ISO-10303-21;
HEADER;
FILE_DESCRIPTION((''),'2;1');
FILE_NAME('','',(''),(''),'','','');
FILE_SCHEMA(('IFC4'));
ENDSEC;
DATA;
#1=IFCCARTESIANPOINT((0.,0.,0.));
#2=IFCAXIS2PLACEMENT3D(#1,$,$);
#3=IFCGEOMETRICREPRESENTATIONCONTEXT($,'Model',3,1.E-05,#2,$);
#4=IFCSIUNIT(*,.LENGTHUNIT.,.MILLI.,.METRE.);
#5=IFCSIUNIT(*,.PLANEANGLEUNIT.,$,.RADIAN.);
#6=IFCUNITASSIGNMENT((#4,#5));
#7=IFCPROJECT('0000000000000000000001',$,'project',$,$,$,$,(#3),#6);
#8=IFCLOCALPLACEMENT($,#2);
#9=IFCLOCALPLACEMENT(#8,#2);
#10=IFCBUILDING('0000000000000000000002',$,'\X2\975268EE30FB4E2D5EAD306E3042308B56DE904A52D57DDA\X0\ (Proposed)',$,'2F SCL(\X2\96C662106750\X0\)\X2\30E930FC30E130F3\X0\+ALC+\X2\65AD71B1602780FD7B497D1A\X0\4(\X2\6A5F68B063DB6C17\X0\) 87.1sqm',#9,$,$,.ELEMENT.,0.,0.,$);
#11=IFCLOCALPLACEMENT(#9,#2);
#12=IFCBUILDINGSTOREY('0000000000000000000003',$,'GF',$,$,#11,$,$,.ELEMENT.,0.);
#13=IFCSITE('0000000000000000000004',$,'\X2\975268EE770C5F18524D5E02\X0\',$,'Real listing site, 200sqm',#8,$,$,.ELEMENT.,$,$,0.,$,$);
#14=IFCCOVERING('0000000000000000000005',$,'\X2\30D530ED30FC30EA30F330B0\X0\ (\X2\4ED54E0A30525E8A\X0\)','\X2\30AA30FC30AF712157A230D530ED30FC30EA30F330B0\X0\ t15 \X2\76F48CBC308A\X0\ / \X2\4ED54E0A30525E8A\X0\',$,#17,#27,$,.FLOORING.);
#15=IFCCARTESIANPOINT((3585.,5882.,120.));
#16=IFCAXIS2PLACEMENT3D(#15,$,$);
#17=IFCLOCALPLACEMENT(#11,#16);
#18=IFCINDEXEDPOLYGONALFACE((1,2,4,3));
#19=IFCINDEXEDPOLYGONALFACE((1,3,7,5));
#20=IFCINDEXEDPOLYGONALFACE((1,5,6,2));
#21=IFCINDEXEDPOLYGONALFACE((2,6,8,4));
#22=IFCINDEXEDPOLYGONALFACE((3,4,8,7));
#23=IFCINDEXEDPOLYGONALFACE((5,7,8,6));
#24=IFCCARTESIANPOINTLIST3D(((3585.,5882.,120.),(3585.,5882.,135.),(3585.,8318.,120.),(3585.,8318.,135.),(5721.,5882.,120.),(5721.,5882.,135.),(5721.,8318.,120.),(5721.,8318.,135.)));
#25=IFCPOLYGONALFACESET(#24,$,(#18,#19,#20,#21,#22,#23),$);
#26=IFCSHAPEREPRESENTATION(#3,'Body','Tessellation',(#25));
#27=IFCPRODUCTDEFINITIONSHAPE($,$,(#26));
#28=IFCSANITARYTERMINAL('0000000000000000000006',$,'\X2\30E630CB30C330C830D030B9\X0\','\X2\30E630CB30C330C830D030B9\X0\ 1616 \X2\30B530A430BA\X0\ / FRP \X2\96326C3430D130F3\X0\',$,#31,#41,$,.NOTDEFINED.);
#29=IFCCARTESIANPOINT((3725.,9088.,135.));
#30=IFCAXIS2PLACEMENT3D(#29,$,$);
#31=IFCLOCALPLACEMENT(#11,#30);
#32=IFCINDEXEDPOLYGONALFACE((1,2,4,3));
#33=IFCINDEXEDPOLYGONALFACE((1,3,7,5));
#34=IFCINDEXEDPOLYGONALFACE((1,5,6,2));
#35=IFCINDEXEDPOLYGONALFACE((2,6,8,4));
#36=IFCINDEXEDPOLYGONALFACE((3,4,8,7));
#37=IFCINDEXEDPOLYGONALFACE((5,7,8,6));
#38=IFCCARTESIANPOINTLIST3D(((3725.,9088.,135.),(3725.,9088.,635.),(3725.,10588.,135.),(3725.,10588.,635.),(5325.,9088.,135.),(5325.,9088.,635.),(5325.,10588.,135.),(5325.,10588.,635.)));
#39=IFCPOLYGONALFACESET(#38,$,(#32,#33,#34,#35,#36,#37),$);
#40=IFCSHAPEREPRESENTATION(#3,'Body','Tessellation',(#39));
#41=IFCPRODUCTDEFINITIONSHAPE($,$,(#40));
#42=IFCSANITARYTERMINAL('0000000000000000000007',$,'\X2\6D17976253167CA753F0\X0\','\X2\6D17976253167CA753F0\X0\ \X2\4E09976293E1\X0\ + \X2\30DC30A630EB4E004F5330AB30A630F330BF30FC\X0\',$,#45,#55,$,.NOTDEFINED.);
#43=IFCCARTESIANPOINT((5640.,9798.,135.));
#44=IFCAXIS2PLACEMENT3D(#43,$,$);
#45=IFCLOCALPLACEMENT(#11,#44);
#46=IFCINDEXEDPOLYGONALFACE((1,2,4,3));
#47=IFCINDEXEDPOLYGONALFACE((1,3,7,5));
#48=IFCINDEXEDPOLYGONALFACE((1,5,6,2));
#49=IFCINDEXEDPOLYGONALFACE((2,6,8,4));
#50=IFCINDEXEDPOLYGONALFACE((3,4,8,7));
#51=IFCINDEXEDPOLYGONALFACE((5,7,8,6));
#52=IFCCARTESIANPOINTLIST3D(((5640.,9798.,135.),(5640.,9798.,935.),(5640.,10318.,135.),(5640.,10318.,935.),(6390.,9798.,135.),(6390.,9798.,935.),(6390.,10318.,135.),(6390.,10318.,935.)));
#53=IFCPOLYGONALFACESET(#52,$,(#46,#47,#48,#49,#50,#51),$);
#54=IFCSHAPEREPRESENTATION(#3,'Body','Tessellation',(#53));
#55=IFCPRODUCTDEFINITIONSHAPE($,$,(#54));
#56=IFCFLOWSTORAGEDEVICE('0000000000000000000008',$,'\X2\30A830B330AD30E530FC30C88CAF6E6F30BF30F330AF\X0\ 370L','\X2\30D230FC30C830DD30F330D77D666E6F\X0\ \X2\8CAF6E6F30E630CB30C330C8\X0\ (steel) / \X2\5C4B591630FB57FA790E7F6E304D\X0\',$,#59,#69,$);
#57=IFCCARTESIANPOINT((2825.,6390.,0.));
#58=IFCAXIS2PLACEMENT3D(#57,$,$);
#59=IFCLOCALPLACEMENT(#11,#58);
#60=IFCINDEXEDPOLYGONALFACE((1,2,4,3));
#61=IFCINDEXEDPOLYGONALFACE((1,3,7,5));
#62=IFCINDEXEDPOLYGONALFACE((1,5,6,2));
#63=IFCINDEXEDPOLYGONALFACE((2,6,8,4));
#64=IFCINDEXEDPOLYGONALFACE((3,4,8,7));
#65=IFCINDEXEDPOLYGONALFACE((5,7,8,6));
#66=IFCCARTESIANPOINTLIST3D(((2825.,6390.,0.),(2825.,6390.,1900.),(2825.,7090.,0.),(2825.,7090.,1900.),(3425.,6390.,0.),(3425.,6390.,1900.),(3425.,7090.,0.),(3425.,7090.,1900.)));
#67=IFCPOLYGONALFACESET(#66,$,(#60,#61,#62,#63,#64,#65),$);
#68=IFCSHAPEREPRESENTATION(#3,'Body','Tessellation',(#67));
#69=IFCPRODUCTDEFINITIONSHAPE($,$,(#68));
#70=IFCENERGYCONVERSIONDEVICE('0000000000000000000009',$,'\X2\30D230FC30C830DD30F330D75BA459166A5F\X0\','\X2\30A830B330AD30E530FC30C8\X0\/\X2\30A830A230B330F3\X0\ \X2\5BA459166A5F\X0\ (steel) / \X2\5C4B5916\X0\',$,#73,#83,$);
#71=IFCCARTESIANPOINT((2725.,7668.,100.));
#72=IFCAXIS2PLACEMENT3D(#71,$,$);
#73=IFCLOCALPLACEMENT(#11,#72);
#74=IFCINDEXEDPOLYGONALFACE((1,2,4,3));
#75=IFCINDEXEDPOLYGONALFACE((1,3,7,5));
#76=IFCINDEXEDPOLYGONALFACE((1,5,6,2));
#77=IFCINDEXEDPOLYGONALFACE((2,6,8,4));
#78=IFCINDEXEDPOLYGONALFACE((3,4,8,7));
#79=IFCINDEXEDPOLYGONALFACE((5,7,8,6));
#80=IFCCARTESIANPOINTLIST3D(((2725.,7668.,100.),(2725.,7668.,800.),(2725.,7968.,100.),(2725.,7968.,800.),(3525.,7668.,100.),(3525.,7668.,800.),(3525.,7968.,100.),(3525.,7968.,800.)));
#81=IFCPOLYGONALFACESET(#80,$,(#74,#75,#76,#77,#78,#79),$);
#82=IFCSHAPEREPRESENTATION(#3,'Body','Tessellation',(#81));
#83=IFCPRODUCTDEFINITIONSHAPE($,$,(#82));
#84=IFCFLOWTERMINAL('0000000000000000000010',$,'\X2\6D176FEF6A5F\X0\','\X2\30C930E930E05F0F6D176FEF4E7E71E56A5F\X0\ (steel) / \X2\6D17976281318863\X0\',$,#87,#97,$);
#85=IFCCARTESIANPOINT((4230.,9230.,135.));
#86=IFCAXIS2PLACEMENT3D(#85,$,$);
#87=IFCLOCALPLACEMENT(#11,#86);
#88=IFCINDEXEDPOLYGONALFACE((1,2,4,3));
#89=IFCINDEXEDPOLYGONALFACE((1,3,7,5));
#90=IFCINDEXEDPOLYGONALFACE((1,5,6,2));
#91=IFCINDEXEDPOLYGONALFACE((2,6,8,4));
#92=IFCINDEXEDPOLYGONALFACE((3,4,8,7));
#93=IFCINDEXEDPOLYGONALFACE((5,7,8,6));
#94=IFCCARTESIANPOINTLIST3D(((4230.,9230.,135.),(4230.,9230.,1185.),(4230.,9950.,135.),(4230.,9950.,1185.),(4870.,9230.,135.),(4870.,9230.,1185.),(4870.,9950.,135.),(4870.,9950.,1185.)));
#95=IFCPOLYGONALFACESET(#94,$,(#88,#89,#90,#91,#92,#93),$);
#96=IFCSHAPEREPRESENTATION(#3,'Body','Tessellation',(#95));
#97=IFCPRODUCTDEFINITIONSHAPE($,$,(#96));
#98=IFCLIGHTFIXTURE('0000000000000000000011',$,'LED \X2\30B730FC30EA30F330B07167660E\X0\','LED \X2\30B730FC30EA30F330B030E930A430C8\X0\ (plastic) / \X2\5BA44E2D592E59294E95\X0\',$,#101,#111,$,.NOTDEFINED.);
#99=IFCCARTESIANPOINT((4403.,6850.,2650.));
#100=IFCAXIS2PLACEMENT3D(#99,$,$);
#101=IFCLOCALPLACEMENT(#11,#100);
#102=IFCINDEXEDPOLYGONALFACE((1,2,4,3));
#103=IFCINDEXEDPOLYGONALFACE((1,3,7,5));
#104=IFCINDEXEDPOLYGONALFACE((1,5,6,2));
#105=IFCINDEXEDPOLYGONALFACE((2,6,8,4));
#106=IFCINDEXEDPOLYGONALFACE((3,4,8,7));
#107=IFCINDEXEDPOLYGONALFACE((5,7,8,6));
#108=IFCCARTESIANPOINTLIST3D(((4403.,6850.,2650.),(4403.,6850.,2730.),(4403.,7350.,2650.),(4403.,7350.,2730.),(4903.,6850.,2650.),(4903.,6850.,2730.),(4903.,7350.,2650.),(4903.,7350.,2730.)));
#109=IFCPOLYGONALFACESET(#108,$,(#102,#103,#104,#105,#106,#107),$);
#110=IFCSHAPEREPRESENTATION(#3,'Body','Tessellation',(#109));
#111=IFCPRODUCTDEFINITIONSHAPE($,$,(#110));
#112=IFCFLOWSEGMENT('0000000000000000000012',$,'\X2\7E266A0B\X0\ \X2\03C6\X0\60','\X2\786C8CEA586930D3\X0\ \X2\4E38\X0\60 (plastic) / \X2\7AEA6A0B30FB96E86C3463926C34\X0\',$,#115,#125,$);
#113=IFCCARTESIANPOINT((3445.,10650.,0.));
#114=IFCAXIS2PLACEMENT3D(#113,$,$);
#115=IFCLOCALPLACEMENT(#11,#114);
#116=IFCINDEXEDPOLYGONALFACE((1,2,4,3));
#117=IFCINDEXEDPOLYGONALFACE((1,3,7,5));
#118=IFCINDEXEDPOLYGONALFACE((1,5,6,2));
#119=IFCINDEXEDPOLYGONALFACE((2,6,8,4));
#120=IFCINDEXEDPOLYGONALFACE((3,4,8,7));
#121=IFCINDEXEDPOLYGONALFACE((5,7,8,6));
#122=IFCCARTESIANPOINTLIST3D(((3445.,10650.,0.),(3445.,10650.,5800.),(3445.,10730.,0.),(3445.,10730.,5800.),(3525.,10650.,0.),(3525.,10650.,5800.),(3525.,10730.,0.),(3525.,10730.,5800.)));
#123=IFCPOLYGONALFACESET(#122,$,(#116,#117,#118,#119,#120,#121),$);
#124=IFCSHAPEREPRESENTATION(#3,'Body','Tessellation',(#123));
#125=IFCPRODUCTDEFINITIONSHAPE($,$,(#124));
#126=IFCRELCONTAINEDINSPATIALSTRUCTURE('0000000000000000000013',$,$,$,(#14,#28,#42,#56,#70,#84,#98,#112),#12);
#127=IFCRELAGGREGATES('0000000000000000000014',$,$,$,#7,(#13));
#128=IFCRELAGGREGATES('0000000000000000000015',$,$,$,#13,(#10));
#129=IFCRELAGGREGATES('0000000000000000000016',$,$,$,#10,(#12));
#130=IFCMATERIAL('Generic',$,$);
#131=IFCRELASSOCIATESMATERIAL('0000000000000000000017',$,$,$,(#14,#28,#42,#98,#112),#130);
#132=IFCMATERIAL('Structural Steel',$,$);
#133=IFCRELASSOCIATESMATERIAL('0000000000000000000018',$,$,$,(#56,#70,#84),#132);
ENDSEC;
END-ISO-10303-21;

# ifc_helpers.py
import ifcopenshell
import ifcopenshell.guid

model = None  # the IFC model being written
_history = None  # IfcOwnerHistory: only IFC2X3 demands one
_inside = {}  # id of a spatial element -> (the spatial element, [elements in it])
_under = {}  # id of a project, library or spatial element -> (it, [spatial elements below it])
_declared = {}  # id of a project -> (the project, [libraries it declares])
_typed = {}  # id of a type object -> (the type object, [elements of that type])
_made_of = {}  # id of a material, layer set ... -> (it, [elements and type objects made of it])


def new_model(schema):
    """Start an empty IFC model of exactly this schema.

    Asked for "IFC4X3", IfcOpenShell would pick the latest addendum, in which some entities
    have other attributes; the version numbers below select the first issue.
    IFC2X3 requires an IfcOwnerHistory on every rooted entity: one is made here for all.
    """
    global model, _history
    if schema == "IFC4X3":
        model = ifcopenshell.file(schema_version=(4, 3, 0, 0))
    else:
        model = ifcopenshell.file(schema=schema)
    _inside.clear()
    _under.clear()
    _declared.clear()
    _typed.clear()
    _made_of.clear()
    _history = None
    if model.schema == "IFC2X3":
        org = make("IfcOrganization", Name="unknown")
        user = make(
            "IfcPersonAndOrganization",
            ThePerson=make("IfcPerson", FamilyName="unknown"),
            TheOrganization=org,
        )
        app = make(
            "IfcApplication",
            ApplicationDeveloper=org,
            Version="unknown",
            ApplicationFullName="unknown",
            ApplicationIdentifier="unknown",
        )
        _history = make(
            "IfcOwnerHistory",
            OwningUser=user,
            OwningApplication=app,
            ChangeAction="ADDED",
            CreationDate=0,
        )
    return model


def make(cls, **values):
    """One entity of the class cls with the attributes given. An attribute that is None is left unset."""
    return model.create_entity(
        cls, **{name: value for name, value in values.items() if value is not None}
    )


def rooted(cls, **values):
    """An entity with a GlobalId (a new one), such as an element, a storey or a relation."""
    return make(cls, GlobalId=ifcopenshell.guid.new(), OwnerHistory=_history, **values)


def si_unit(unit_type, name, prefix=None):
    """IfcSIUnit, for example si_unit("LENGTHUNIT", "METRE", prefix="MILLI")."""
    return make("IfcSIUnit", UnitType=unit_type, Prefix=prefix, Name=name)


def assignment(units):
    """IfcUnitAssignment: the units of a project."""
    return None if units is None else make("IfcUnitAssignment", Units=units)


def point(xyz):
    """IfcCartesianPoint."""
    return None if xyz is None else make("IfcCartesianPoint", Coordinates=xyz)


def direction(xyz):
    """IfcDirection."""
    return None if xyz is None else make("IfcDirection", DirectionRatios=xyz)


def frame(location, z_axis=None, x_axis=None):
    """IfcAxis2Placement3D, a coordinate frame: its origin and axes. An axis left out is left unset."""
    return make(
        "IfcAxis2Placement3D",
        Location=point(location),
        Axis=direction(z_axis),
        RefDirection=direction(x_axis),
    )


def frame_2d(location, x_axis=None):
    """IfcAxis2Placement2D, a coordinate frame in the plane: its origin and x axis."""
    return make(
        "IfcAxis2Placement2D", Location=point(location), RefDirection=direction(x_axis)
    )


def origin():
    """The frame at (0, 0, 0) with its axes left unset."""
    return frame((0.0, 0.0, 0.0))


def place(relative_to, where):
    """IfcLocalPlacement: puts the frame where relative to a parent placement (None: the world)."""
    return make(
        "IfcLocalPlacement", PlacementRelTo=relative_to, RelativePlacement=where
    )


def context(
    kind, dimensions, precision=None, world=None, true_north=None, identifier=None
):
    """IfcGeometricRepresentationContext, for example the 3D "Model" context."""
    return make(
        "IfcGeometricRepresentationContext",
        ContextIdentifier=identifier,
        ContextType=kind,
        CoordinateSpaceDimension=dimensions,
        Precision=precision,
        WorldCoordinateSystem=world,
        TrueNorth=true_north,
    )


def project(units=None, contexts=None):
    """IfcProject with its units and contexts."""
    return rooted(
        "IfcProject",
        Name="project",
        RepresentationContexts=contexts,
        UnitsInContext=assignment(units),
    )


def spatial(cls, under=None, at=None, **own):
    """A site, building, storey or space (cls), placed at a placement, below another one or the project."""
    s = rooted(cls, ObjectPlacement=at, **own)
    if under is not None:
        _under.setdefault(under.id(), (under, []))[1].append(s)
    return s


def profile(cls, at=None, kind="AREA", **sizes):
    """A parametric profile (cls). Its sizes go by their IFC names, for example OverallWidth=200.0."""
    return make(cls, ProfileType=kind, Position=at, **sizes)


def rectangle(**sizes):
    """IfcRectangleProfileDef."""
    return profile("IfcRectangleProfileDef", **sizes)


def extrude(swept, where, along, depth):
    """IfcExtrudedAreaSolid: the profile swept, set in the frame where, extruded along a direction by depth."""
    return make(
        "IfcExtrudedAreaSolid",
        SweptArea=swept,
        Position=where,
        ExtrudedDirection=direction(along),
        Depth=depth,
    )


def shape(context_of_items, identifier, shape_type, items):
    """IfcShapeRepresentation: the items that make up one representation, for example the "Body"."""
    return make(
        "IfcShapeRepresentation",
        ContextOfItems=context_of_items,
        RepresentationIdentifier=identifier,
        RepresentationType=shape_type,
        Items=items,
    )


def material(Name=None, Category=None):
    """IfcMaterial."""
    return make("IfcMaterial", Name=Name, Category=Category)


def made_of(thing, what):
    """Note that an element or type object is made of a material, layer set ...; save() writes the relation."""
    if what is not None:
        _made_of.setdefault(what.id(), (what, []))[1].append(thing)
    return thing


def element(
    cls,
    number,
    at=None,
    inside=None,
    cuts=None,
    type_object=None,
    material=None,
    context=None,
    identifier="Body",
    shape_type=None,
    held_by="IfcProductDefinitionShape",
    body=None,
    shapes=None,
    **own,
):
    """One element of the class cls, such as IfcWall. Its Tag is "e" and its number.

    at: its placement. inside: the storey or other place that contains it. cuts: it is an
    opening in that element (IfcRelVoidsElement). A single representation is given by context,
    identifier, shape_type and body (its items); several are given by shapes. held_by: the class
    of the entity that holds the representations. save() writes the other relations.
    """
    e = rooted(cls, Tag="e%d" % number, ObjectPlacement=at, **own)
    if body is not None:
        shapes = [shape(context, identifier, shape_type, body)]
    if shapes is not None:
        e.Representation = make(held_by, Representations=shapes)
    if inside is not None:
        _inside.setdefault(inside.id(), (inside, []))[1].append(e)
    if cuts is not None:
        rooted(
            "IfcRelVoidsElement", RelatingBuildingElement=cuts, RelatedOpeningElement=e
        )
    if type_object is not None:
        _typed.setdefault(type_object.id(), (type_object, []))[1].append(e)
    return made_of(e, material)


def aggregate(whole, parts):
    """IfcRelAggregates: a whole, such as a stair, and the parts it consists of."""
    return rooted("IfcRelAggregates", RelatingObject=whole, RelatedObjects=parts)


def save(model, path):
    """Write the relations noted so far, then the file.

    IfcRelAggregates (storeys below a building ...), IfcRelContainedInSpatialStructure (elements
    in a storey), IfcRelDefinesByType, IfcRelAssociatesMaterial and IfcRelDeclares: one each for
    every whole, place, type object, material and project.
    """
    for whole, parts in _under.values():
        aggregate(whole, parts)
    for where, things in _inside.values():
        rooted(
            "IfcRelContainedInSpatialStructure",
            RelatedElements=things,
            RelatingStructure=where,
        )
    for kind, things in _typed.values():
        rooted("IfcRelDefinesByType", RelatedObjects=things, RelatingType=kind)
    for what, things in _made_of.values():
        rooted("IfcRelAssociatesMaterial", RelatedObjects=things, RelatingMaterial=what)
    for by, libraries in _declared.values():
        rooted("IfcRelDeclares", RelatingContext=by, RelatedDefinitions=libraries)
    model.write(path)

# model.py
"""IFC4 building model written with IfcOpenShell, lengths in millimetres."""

from ifc_helpers import new_model, si_unit, frame, frame_2d, origin, place, context, project, spatial, rectangle, extrude, material, element, save


model = new_model("IFC4")

# Units and contexts
model_context = context("Model", 3, precision=1e-05, world=origin())
ifc_project = project(units=[si_unit("LENGTHUNIT", "METRE", prefix="MILLI"), si_unit("PLANEANGLEUNIT", "RADIAN")], contexts=[model_context])

# Site, building, storey
site_placement = place(None, origin())
site = spatial("IfcSite", under=ifc_project, at=site_placement, Name="青森県弘前市", ObjectType="Real listing site, 200sqm", CompositionType="ELEMENT", RefElevation=0.0)
building_placement = place(site_placement, origin())
building = spatial("IfcBuilding", under=site, at=building_placement, Name="青森・中庭のある回遊動線 (Proposed)", ObjectType="2F SCL(集成材)ラーメン+ALC+断熱性能等級4(機械換気) 87.1sqm", CompositionType="ELEMENT", ElevationOfRefHeight=0.0, ElevationOfTerrain=0.0)
storey_placement = place(building_placement, origin())
storey = spatial("IfcBuildingStorey", under=building, at=storey_placement, Name="GF", CompositionType="ELEMENT", Elevation=0.0)

# Covering
ifc_material_1 = material(Name="Generic")
covering_1_placement = place(storey_placement, frame((3585.0, 5882.0, 120.0)))
element("IfcCovering", 1, at=covering_1_placement, inside=storey, material=ifc_material_1, Name="フローリング (仕上げ床)", Description="オーク無垢フローリング t15 直貼り / 仕上げ床", PredefinedType="FLOORING", context=model_context, shape_type="SweptSolid", body=[
    extrude(rectangle(XDim=2136.0, YDim=2436.0, at=frame_2d((1068.0, 1218.0))), frame((3585.0, 5882.0, 120.0)), (0.0, 0.0, 1.0), 15.0),
])

# Sanitary terminals
sanitary_terminal_1_placement = place(storey_placement, frame((3725.0, 9088.0, 135.0)))
element("IfcSanitaryTerminal", 2, at=sanitary_terminal_1_placement, inside=storey, material=ifc_material_1, Name="ユニットバス", Description="ユニットバス 1616 サイズ / FRP 防水パン", PredefinedType="NOTDEFINED", context=model_context, shape_type="SweptSolid", body=[
    extrude(rectangle(XDim=1600.0, YDim=1500.0, at=frame_2d((800.0, 750.0))), frame((3725.0, 9088.0, 135.0)), (0.0, 0.0, 1.0), 500.0),
])
sanitary_terminal_2_placement = place(storey_placement, frame((5640.0, 9798.0, 135.0)))
element("IfcSanitaryTerminal", 3, at=sanitary_terminal_2_placement, inside=storey, material=ifc_material_1, Name="洗面化粧台", Description="洗面化粧台 三面鏡 + ボウル一体カウンター", PredefinedType="NOTDEFINED", context=model_context, shape_type="SweptSolid", body=[
    extrude(rectangle(XDim=750.0, YDim=520.0, at=frame_2d((375.0, 260.0))), frame((5640.0, 9798.0, 135.0)), (0.0, 0.0, 1.0), 800.0),
])

# Flow storage device
ifc_material_2 = material(Name="Structural Steel")
flow_storage_device_placement = place(storey_placement, frame((2825.0, 6390.0, 0.0)))
element("IfcFlowStorageDevice", 4, at=flow_storage_device_placement, inside=storey, material=ifc_material_2, Name="エコキュート貯湯タンク 370L", Description="ヒートポンプ給湯 貯湯ユニット (steel) / 屋外・基礎置き", context=model_context, shape_type="SweptSolid", body=[
    extrude(rectangle(XDim=600.0, YDim=700.0, at=frame_2d((300.0, 350.0))), frame((2825.0, 6390.0, 0.0)), (0.0, 0.0, 1.0), 1900.0),
])

# Energy conversion device
energy_conversion_device_placement = place(storey_placement, frame((2725.0, 7668.0, 100.0)))
element("IfcEnergyConversionDevice", 5, at=energy_conversion_device_placement, inside=storey, material=ifc_material_2, Name="ヒートポンプ室外機", Description="エコキュート/エアコン 室外機 (steel) / 屋外", context=model_context, shape_type="SweptSolid", body=[
    extrude(rectangle(XDim=800.0, YDim=300.0, at=frame_2d((400.0, 150.0))), frame((2725.0, 7668.0, 100.0)), (0.0, 0.0, 1.0), 700.0),
])

# Flow terminal
flow_terminal_placement = place(storey_placement, frame((4230.0, 9230.0, 135.0)))
element("IfcFlowTerminal", 6, at=flow_terminal_placement, inside=storey, material=ifc_material_2, Name="洗濯機", Description="ドラム式洗濯乾燥機 (steel) / 洗面脱衣", context=model_context, shape_type="SweptSolid", body=[
    extrude(rectangle(XDim=640.0, YDim=720.0, at=frame_2d((320.0, 360.0))), frame((4230.0, 9230.0, 135.0)), (0.0, 0.0, 1.0), 1050.0),
])

# Light fixture
light_fixture_placement = place(storey_placement, frame((4403.0, 6850.0, 2650.0)))
element("IfcLightFixture", 7, at=light_fixture_placement, inside=storey, material=ifc_material_1, Name="LED シーリング照明", Description="LED シーリングライト (plastic) / 室中央天井", PredefinedType="NOTDEFINED", context=model_context, shape_type="SweptSolid", body=[
    extrude(rectangle(XDim=500.0, YDim=500.0, at=frame_2d((250.0, 250.0))), frame((4403.0, 6850.0, 2650.0)), (0.0, 0.0, 1.0), 80.0),
])

# Flow segment
flow_segment_placement = place(storey_placement, frame((3445.0, 10650.0, 0.0)))
element("IfcFlowSegment", 8, at=flow_segment_placement, inside=storey, material=ifc_material_1, Name="縦樋 φ60", Description="硬質塩ビ 丸60 (plastic) / 竪樋・雨水排水", context=model_context, shape_type="SweptSolid", body=[
    extrude(rectangle(XDim=80.0, YDim=80.0, at=frame_2d((40.0, 40.0))), frame((3445.0, 10650.0, 0.0)), (0.0, 0.0, 1.0), 5800.0),
])

save(model, "model.ifc")
